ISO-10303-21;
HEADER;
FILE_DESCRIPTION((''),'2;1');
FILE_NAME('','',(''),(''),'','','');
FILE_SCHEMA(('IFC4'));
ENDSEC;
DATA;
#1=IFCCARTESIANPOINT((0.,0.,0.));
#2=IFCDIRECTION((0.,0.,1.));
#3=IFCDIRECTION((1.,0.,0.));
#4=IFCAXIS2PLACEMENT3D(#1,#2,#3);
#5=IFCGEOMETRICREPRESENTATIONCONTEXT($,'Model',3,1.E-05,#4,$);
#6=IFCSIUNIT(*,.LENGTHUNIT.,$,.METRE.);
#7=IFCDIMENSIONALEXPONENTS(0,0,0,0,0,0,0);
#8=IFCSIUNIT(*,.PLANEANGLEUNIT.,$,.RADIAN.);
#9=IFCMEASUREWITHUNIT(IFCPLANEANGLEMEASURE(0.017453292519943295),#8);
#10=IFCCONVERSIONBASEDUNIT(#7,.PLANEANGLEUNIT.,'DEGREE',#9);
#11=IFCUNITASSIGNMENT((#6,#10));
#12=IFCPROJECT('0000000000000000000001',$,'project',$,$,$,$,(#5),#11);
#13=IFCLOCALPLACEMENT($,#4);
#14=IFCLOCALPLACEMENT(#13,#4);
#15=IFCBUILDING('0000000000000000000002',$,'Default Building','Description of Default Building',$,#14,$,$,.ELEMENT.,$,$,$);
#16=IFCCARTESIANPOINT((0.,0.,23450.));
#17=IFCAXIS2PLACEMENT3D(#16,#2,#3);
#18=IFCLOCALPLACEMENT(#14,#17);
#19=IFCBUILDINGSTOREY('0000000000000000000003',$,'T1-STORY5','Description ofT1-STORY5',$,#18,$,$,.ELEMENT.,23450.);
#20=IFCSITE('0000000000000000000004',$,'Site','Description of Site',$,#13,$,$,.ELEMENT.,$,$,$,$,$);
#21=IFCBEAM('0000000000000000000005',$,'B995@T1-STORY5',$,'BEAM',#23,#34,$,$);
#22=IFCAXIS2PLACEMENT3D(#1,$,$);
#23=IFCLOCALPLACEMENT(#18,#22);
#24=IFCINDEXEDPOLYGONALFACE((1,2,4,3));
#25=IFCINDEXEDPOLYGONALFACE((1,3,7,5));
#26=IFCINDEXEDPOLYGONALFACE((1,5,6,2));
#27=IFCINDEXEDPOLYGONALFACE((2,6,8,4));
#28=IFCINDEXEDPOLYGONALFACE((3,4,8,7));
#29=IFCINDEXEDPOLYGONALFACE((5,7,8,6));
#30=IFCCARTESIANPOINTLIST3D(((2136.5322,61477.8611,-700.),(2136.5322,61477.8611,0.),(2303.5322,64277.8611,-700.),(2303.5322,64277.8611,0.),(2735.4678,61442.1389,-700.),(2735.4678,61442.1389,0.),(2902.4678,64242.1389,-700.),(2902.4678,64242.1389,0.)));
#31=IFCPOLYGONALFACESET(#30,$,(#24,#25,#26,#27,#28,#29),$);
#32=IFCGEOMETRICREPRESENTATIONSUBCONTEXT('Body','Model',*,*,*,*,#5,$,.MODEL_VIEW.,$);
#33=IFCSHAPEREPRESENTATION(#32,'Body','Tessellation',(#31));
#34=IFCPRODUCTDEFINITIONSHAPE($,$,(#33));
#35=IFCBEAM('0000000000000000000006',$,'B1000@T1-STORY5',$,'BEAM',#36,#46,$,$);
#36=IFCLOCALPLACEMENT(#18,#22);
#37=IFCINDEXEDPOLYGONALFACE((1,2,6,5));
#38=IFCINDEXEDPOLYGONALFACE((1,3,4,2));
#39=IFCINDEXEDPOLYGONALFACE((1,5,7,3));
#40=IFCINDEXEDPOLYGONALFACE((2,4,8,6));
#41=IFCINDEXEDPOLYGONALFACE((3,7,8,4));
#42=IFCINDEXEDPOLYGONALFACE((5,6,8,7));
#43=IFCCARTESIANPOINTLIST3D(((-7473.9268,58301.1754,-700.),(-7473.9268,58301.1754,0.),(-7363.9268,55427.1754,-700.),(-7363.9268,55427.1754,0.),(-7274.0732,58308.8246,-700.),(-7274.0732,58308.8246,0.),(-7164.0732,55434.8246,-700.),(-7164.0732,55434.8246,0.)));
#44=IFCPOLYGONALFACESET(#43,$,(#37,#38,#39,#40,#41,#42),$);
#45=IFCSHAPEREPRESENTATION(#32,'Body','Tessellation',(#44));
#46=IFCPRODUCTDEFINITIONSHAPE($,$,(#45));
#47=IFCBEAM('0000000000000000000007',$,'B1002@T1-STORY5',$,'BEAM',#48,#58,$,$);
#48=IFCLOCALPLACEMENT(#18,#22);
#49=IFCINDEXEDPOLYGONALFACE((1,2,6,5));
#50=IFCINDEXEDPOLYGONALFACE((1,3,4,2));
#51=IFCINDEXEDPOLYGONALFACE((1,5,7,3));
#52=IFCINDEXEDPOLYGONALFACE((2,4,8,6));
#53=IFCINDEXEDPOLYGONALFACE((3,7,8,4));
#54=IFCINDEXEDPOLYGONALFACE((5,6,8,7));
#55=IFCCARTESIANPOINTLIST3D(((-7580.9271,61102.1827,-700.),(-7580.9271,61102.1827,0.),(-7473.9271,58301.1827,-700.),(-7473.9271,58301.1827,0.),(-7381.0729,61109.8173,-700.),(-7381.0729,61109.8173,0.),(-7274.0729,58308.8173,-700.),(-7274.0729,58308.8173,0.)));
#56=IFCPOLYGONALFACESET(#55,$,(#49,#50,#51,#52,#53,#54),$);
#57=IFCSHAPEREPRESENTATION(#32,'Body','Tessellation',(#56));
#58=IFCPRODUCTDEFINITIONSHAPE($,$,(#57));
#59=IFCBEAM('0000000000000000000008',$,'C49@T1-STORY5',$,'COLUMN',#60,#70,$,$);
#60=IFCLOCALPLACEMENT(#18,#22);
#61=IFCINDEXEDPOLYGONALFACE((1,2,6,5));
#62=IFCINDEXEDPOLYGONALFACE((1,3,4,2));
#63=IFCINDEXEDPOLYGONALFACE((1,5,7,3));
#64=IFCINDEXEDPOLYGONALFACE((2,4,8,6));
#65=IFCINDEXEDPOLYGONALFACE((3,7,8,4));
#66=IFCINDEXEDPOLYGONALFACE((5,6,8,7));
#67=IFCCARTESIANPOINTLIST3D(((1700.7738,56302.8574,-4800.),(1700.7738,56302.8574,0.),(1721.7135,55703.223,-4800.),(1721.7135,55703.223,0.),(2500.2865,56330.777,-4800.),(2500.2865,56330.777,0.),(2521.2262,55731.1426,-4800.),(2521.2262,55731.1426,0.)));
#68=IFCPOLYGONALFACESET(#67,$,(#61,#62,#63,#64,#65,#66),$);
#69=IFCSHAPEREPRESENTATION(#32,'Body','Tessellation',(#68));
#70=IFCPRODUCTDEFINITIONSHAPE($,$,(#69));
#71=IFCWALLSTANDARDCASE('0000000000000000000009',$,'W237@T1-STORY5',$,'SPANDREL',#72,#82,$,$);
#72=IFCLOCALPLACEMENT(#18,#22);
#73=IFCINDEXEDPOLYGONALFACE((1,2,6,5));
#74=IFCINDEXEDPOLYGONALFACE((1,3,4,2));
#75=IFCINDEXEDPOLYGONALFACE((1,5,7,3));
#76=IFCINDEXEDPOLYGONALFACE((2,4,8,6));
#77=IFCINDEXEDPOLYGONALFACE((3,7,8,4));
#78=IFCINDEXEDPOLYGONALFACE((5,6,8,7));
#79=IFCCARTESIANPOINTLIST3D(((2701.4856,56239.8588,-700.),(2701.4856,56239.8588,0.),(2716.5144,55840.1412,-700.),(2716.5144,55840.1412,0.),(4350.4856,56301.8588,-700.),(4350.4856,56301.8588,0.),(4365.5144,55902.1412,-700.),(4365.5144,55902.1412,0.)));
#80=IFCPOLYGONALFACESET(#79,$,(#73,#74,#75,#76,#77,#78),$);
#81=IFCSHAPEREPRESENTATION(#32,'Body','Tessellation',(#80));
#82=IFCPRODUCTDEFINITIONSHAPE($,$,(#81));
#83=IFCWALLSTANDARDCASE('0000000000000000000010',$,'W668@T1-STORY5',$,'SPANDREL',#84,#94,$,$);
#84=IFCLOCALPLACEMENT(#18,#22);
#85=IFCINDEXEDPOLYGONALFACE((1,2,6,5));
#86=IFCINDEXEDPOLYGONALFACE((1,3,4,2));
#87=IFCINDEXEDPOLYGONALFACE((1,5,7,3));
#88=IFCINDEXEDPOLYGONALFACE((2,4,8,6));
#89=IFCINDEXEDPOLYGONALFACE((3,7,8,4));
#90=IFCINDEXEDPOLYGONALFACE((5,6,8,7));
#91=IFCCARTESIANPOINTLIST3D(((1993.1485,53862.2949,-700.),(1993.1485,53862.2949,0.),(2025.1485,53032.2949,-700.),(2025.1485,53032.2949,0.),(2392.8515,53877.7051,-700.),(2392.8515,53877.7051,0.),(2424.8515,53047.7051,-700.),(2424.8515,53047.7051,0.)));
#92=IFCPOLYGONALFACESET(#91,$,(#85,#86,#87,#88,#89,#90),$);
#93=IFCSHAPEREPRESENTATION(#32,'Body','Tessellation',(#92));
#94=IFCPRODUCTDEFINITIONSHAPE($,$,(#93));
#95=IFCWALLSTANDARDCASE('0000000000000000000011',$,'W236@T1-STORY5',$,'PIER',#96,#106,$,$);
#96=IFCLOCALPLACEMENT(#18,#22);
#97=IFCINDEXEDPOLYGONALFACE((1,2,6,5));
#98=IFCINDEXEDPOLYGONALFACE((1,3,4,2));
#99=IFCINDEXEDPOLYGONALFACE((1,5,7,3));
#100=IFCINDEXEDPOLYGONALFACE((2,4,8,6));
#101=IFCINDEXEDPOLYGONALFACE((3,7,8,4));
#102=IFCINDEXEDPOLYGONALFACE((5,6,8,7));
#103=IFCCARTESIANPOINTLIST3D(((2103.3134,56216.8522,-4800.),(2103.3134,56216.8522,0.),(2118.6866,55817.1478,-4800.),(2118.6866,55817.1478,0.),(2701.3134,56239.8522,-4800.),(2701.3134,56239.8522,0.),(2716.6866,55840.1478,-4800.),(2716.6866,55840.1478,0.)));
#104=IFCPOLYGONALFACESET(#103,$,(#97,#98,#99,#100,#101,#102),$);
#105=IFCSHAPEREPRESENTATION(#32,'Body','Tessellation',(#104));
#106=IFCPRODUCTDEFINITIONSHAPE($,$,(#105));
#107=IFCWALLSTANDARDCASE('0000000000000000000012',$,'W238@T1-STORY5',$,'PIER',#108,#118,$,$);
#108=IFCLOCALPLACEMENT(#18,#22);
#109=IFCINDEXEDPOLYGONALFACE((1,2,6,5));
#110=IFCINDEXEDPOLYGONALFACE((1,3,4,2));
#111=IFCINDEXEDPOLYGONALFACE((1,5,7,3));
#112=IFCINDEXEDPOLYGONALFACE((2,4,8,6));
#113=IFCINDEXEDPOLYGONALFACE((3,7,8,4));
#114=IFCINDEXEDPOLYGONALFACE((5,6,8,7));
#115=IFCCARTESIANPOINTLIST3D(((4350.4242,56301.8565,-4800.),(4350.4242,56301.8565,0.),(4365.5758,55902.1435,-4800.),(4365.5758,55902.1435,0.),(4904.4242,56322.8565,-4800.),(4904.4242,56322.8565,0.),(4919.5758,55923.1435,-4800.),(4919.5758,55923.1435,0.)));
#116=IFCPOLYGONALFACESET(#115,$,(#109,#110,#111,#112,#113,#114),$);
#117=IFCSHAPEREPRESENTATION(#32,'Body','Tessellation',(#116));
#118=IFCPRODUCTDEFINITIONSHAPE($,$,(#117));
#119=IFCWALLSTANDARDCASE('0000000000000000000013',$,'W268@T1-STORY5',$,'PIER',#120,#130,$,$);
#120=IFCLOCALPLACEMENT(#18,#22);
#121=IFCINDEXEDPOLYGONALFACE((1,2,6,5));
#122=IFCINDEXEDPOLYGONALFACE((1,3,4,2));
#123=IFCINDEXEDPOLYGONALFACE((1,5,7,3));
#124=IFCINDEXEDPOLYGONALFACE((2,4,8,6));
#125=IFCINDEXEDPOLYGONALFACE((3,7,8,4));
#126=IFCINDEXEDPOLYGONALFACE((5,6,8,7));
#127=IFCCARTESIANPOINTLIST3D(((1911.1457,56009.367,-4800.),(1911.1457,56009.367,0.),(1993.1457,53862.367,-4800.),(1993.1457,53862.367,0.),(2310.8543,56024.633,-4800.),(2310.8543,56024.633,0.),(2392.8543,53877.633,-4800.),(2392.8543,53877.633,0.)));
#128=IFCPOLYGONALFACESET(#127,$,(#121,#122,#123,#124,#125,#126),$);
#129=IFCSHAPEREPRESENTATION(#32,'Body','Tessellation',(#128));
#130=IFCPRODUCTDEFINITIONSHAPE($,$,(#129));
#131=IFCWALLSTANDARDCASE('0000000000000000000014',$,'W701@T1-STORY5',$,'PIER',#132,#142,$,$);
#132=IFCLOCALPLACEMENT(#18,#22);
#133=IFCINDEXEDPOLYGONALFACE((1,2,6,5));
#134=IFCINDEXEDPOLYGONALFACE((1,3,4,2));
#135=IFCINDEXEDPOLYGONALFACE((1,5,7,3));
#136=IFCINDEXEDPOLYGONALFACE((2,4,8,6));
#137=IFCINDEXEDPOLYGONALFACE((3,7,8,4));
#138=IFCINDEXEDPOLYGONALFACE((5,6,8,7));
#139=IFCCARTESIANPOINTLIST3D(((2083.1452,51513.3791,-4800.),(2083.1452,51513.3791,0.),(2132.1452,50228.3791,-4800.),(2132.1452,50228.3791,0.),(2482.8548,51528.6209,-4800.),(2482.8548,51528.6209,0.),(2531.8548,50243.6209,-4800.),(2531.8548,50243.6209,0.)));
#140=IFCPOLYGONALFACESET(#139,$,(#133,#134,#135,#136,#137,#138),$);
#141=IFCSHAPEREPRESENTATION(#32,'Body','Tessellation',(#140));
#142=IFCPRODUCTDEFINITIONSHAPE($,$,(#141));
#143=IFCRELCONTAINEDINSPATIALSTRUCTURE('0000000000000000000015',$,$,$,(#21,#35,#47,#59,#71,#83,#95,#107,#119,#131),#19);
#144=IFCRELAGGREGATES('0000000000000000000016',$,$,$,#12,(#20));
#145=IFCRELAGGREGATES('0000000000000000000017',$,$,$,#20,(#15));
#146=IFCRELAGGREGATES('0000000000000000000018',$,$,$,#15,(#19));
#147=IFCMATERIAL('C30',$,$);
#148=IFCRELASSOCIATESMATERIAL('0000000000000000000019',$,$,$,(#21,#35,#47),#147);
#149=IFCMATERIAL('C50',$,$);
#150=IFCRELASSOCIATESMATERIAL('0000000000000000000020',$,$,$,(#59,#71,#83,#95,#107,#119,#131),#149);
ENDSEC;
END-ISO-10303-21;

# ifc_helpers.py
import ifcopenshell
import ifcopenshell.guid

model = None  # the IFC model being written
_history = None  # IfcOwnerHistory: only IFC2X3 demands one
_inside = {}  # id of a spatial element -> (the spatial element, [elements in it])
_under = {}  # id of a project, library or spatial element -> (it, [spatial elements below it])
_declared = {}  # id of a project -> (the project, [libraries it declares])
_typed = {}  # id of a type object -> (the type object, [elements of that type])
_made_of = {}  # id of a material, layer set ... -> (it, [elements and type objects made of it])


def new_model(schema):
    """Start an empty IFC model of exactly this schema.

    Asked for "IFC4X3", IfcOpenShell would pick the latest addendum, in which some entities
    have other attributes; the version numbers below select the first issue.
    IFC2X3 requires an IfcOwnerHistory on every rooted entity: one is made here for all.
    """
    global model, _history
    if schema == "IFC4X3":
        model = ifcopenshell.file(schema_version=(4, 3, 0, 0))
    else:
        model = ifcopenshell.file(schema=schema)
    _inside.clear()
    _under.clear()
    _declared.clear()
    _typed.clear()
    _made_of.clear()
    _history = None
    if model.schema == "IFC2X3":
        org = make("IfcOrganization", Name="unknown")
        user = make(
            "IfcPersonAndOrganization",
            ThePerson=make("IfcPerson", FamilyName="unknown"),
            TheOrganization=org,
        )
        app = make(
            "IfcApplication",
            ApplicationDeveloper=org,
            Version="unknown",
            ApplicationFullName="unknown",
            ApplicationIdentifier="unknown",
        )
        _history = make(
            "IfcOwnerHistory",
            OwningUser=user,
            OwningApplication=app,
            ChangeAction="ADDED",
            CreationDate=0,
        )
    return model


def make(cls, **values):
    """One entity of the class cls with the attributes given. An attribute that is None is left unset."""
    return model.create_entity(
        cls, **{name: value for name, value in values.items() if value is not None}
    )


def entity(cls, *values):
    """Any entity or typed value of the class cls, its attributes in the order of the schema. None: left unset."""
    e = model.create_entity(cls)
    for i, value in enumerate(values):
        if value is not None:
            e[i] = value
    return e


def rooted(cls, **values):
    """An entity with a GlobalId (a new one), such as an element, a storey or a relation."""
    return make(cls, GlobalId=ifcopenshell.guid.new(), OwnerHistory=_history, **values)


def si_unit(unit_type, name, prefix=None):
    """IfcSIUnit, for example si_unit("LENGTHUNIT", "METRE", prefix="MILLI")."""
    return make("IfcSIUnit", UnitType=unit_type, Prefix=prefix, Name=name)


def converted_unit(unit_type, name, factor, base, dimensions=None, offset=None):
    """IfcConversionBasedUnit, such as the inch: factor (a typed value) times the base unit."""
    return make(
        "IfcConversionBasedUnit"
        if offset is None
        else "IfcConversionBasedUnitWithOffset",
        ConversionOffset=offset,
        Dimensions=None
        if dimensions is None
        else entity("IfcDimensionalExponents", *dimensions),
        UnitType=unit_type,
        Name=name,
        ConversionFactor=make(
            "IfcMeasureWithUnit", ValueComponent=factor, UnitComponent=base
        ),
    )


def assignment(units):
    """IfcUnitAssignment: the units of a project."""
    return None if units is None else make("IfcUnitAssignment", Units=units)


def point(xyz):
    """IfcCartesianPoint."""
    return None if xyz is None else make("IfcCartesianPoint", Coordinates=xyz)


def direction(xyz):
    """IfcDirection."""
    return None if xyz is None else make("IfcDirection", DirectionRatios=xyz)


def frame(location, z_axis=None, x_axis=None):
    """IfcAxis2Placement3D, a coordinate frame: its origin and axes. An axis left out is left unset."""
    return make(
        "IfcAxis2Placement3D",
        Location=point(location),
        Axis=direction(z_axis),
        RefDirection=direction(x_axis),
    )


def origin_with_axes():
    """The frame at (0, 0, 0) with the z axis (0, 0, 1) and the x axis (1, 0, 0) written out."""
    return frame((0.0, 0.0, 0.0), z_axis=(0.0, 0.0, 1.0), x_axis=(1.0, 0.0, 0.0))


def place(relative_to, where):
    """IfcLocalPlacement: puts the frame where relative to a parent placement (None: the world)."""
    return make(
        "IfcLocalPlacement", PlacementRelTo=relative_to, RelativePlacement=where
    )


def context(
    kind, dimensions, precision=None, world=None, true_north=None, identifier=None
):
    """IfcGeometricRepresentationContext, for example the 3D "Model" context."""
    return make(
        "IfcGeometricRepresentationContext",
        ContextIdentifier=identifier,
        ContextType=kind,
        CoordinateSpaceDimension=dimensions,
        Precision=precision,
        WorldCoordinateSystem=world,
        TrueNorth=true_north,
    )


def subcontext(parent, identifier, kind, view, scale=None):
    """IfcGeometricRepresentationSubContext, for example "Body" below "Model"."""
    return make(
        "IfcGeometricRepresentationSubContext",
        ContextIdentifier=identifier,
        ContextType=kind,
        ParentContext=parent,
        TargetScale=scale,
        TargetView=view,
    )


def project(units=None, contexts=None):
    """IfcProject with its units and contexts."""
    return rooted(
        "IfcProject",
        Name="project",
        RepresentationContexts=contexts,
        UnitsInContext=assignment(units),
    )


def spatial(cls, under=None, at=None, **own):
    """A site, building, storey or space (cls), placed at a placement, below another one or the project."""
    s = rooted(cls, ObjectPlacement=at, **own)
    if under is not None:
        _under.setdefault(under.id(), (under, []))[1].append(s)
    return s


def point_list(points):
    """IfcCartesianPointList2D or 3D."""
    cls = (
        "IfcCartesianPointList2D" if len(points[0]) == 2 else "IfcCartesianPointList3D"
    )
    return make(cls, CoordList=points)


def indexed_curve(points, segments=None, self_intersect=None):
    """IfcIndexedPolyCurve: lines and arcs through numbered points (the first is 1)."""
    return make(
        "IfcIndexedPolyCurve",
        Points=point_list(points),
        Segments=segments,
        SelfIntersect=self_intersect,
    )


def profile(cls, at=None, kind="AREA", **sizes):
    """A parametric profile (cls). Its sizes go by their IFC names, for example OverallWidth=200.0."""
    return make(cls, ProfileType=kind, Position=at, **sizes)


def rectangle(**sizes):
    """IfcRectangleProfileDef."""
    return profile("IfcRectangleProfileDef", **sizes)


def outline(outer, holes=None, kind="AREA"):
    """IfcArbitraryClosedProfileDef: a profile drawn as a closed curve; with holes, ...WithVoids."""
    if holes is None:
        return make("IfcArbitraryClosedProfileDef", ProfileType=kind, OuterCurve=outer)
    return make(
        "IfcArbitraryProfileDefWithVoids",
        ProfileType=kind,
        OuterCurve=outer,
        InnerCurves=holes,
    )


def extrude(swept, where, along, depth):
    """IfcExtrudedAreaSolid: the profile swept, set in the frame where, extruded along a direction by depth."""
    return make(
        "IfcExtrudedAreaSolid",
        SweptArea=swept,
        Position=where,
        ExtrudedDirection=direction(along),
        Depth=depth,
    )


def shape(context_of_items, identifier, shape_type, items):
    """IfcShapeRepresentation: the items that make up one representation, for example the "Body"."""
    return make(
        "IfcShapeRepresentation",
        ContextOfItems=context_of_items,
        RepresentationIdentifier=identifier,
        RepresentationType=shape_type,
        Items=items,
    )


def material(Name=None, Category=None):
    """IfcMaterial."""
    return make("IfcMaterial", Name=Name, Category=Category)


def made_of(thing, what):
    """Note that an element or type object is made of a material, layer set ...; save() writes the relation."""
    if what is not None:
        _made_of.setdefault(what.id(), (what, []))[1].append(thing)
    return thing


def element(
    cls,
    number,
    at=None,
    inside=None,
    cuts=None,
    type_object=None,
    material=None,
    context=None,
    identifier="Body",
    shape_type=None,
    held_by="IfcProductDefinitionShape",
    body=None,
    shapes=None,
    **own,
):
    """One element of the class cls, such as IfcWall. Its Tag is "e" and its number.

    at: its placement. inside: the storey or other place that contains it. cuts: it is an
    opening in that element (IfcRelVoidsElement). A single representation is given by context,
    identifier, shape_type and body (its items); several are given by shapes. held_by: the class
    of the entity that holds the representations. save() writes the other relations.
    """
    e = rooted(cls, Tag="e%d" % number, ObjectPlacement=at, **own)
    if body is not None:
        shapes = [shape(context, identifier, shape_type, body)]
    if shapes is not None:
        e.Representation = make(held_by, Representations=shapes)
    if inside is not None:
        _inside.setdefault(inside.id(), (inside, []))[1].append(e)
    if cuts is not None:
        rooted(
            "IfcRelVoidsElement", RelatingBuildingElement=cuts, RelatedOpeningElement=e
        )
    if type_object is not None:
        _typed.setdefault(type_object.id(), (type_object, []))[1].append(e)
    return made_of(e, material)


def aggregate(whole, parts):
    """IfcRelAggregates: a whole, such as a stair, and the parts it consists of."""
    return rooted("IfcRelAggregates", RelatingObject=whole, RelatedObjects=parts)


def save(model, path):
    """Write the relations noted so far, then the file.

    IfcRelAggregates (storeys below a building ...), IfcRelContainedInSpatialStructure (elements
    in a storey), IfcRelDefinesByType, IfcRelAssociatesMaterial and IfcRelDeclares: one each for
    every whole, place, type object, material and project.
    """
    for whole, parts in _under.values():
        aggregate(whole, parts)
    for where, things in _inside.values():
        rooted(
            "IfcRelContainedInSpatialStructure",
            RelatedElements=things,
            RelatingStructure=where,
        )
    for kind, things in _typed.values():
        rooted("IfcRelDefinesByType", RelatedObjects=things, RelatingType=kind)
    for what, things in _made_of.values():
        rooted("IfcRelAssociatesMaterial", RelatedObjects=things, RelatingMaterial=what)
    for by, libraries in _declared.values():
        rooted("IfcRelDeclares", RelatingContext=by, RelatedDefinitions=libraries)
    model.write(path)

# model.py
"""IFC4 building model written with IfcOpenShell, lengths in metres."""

from ifc_helpers import new_model, entity, si_unit, converted_unit, frame, origin_with_axes, place, context, subcontext, project, spatial, indexed_curve, rectangle, outline, extrude, material, element, save


model = new_model("IFC4")

# Units and contexts
model_context = context("Model", 3, precision=1e-05, world=origin_with_axes())
body_context = subcontext(model_context, "Body", "Model", "MODEL_VIEW")
ifc_project = project(units=[si_unit("LENGTHUNIT", "METRE"), converted_unit("PLANEANGLEUNIT", "DEGREE", entity("IfcPlaneAngleMeasure", 0.017453292519943295), si_unit("PLANEANGLEUNIT", "RADIAN"), dimensions=[0, 0, 0, 0, 0, 0, 0])], contexts=[model_context])

# Site, building, storey
site_placement = place(None, origin_with_axes())
site = spatial("IfcSite", under=ifc_project, at=site_placement, Name="Site", Description="Description of Site", CompositionType="ELEMENT")
building_placement = place(site_placement, origin_with_axes())
building = spatial("IfcBuilding", under=site, at=building_placement, Name="Default Building", Description="Description of Default Building", CompositionType="ELEMENT")
storey_placement = place(building_placement, frame((0.0, 0.0, 23450.0), z_axis=(0.0, 0.0, 1.0), x_axis=(1.0, 0.0, 0.0)))
storey = spatial("IfcBuildingStorey", under=building, at=storey_placement, Name="T1-STORY5", Description="Description ofT1-STORY5", CompositionType="ELEMENT", Elevation=23450.0)

# Beams
ifc_material_1 = material(Name="C30")
beam_1_placement = place(storey_placement, frame((2436.0, 61460.0, -350.0), z_axis=(0.059537, 0.998226, 0.0), x_axis=(-0.998226, 0.059537, 0.0)))
element("IfcBeam", 1, at=beam_1_placement, inside=storey, material=ifc_material_1, Name="B995@T1-STORY5", ObjectType="BEAM", context=body_context, shape_type="SweptSolid", body=[
    extrude(rectangle(XDim=600.0, YDim=700.0), origin_with_axes(), (0.0, 0.0, 1.0), 2804.9758),
])
beam_2_placement = place(storey_placement, frame((-7374.0, 58305.0, -350.0), z_axis=(0.038246, -0.999268, 0.0), x_axis=(0.999268, 0.038246, 0.0)))
element("IfcBeam", 2, at=beam_2_placement, inside=storey, material=ifc_material_1, Name="B1000@T1-STORY5", ObjectType="BEAM", context=body_context, shape_type="SweptSolid", body=[
    extrude(rectangle(XDim=200.0, YDim=700.0), origin_with_axes(), (0.0, 0.0, 1.0), 2876.1043),
])
beam_3_placement = place(storey_placement, frame((-7481.0, 61106.0, -350.0), z_axis=(0.038173, -0.999271, 0.0), x_axis=(0.999271, 0.038173, 0.0)))
element("IfcBeam", 3, at=beam_3_placement, inside=storey, material=ifc_material_1, Name="B1002@T1-STORY5", ObjectType="BEAM", context=body_context, shape_type="SweptSolid", body=[
    extrude(rectangle(XDim=200.0, YDim=700.0), origin_with_axes(), (0.0, 0.0, 1.0), 2803.043),
])
ifc_material_2 = material(Name="C50")
beam_4_placement = place(storey_placement, frame((2111.0, 56017.0, -4800.0), z_axis=(0.0, 0.0, 1.0), x_axis=(-0.999391, -0.034899, 0.0)))
element("IfcBeam", 4, at=beam_4_placement, inside=storey, material=ifc_material_2, Name="C49@T1-STORY5", ObjectType="COLUMN", context=body_context, shape_type="SweptSolid", body=[
    extrude(rectangle(XDim=800.0, YDim=600.0), origin_with_axes(), (0.0, 0.0, 1.0), 4800.0),
])

# Walls
wall_1_placement = place(storey_placement, frame((2709.0, 56040.0, -700.0), z_axis=(0.0, 0.0, 1.0), x_axis=(0.999294, 0.037572, 0.0)))
element("IfcWallStandardCase", 5, at=wall_1_placement, inside=storey, material=ifc_material_2, Name="W237@T1-STORY5", ObjectType="SPANDREL", context=body_context, shape_type="SweptSolid", body=[
    extrude(outline(indexed_curve([(0.0, -200.0), (0.0, 200.0), (1650.1651, 200.0), (1650.1651, -200.0), (0.0, -200.0)], self_intersect=False)), origin_with_axes(), (0.0, 0.0, 1.0), 700.0),
])
wall_2_placement = place(storey_placement, frame((2193.0, 53870.0, -700.0), z_axis=(0.0, 0.0, 1.0), x_axis=(0.038526, -0.999258, 0.0)))
element("IfcWallStandardCase", 6, at=wall_2_placement, inside=storey, material=ifc_material_2, Name="W668@T1-STORY5", ObjectType="SPANDREL", context=body_context, shape_type="SweptSolid", body=[
    extrude(outline(indexed_curve([(0.0, -200.0), (0.0, 200.0), (830.6166, 200.0), (830.6166, -200.0), (0.0, -200.0)], self_intersect=False)), origin_with_axes(), (0.0, 0.0, 1.0), 700.0),
])
wall_3_placement = place(storey_placement, frame((2111.0, 56017.0, -4800.0), z_axis=(0.0, 0.0, 1.0), x_axis=(0.999261, 0.038433, 0.0)))
element("IfcWallStandardCase", 7, at=wall_3_placement, inside=storey, material=ifc_material_2, Name="W236@T1-STORY5", ObjectType="PIER", context=body_context, shape_type="SweptSolid", body=[
    extrude(outline(indexed_curve([(0.0, -200.0), (0.0, 200.0), (598.4421, 200.0), (598.4421, -200.0), (0.0, -200.0)], self_intersect=False)), origin_with_axes(), (0.0, 0.0, 1.0), 4800.0),
])
wall_4_placement = place(storey_placement, frame((4358.0, 56102.0, -4800.0), z_axis=(0.0, 0.0, 1.0), x_axis=(0.999282, 0.037879, 0.0)))
element("IfcWallStandardCase", 8, at=wall_4_placement, inside=storey, material=ifc_material_2, Name="W238@T1-STORY5", ObjectType="PIER", context=body_context, shape_type="SweptSolid", body=[
    extrude(outline(indexed_curve([(0.0, -200.0), (0.0, 200.0), (554.3979, 200.0), (554.3979, -200.0), (0.0, -200.0)], self_intersect=False)), origin_with_axes(), (0.0, 0.0, 1.0), 4800.0),
])
wall_5_placement = place(storey_placement, frame((2111.0, 56017.0, -4800.0), z_axis=(0.0, 0.0, 1.0), x_axis=(0.038165, -0.999271, 0.0)))
element("IfcWallStandardCase", 9, at=wall_5_placement, inside=storey, material=ifc_material_2, Name="W268@T1-STORY5", ObjectType="PIER", context=body_context, shape_type="SweptSolid", body=[
    extrude(outline(indexed_curve([(0.0, -200.0), (0.0, 200.0), (2148.5653, 200.0), (2148.5653, -200.0), (0.0, -200.0)], self_intersect=False)), origin_with_axes(), (0.0, 0.0, 1.0), 4800.0),
])
wall_6_placement = place(storey_placement, frame((2283.0, 51521.0, -4800.0), z_axis=(0.0, 0.0, 1.0), x_axis=(0.038105, -0.999274, 0.0)))
element("IfcWallStandardCase", 10, at=wall_6_placement, inside=storey, material=ifc_material_2, Name="W701@T1-STORY5", ObjectType="PIER", context=body_context, shape_type="SweptSolid", body=[
    extrude(outline(indexed_curve([(0.0, -200.0), (0.0, 200.0), (1285.9339, 200.0), (1285.9339, -200.0), (0.0, -200.0)], self_intersect=False)), origin_with_axes(), (0.0, 0.0, 1.0), 4800.0),
])

save(model, "model.ifc")
